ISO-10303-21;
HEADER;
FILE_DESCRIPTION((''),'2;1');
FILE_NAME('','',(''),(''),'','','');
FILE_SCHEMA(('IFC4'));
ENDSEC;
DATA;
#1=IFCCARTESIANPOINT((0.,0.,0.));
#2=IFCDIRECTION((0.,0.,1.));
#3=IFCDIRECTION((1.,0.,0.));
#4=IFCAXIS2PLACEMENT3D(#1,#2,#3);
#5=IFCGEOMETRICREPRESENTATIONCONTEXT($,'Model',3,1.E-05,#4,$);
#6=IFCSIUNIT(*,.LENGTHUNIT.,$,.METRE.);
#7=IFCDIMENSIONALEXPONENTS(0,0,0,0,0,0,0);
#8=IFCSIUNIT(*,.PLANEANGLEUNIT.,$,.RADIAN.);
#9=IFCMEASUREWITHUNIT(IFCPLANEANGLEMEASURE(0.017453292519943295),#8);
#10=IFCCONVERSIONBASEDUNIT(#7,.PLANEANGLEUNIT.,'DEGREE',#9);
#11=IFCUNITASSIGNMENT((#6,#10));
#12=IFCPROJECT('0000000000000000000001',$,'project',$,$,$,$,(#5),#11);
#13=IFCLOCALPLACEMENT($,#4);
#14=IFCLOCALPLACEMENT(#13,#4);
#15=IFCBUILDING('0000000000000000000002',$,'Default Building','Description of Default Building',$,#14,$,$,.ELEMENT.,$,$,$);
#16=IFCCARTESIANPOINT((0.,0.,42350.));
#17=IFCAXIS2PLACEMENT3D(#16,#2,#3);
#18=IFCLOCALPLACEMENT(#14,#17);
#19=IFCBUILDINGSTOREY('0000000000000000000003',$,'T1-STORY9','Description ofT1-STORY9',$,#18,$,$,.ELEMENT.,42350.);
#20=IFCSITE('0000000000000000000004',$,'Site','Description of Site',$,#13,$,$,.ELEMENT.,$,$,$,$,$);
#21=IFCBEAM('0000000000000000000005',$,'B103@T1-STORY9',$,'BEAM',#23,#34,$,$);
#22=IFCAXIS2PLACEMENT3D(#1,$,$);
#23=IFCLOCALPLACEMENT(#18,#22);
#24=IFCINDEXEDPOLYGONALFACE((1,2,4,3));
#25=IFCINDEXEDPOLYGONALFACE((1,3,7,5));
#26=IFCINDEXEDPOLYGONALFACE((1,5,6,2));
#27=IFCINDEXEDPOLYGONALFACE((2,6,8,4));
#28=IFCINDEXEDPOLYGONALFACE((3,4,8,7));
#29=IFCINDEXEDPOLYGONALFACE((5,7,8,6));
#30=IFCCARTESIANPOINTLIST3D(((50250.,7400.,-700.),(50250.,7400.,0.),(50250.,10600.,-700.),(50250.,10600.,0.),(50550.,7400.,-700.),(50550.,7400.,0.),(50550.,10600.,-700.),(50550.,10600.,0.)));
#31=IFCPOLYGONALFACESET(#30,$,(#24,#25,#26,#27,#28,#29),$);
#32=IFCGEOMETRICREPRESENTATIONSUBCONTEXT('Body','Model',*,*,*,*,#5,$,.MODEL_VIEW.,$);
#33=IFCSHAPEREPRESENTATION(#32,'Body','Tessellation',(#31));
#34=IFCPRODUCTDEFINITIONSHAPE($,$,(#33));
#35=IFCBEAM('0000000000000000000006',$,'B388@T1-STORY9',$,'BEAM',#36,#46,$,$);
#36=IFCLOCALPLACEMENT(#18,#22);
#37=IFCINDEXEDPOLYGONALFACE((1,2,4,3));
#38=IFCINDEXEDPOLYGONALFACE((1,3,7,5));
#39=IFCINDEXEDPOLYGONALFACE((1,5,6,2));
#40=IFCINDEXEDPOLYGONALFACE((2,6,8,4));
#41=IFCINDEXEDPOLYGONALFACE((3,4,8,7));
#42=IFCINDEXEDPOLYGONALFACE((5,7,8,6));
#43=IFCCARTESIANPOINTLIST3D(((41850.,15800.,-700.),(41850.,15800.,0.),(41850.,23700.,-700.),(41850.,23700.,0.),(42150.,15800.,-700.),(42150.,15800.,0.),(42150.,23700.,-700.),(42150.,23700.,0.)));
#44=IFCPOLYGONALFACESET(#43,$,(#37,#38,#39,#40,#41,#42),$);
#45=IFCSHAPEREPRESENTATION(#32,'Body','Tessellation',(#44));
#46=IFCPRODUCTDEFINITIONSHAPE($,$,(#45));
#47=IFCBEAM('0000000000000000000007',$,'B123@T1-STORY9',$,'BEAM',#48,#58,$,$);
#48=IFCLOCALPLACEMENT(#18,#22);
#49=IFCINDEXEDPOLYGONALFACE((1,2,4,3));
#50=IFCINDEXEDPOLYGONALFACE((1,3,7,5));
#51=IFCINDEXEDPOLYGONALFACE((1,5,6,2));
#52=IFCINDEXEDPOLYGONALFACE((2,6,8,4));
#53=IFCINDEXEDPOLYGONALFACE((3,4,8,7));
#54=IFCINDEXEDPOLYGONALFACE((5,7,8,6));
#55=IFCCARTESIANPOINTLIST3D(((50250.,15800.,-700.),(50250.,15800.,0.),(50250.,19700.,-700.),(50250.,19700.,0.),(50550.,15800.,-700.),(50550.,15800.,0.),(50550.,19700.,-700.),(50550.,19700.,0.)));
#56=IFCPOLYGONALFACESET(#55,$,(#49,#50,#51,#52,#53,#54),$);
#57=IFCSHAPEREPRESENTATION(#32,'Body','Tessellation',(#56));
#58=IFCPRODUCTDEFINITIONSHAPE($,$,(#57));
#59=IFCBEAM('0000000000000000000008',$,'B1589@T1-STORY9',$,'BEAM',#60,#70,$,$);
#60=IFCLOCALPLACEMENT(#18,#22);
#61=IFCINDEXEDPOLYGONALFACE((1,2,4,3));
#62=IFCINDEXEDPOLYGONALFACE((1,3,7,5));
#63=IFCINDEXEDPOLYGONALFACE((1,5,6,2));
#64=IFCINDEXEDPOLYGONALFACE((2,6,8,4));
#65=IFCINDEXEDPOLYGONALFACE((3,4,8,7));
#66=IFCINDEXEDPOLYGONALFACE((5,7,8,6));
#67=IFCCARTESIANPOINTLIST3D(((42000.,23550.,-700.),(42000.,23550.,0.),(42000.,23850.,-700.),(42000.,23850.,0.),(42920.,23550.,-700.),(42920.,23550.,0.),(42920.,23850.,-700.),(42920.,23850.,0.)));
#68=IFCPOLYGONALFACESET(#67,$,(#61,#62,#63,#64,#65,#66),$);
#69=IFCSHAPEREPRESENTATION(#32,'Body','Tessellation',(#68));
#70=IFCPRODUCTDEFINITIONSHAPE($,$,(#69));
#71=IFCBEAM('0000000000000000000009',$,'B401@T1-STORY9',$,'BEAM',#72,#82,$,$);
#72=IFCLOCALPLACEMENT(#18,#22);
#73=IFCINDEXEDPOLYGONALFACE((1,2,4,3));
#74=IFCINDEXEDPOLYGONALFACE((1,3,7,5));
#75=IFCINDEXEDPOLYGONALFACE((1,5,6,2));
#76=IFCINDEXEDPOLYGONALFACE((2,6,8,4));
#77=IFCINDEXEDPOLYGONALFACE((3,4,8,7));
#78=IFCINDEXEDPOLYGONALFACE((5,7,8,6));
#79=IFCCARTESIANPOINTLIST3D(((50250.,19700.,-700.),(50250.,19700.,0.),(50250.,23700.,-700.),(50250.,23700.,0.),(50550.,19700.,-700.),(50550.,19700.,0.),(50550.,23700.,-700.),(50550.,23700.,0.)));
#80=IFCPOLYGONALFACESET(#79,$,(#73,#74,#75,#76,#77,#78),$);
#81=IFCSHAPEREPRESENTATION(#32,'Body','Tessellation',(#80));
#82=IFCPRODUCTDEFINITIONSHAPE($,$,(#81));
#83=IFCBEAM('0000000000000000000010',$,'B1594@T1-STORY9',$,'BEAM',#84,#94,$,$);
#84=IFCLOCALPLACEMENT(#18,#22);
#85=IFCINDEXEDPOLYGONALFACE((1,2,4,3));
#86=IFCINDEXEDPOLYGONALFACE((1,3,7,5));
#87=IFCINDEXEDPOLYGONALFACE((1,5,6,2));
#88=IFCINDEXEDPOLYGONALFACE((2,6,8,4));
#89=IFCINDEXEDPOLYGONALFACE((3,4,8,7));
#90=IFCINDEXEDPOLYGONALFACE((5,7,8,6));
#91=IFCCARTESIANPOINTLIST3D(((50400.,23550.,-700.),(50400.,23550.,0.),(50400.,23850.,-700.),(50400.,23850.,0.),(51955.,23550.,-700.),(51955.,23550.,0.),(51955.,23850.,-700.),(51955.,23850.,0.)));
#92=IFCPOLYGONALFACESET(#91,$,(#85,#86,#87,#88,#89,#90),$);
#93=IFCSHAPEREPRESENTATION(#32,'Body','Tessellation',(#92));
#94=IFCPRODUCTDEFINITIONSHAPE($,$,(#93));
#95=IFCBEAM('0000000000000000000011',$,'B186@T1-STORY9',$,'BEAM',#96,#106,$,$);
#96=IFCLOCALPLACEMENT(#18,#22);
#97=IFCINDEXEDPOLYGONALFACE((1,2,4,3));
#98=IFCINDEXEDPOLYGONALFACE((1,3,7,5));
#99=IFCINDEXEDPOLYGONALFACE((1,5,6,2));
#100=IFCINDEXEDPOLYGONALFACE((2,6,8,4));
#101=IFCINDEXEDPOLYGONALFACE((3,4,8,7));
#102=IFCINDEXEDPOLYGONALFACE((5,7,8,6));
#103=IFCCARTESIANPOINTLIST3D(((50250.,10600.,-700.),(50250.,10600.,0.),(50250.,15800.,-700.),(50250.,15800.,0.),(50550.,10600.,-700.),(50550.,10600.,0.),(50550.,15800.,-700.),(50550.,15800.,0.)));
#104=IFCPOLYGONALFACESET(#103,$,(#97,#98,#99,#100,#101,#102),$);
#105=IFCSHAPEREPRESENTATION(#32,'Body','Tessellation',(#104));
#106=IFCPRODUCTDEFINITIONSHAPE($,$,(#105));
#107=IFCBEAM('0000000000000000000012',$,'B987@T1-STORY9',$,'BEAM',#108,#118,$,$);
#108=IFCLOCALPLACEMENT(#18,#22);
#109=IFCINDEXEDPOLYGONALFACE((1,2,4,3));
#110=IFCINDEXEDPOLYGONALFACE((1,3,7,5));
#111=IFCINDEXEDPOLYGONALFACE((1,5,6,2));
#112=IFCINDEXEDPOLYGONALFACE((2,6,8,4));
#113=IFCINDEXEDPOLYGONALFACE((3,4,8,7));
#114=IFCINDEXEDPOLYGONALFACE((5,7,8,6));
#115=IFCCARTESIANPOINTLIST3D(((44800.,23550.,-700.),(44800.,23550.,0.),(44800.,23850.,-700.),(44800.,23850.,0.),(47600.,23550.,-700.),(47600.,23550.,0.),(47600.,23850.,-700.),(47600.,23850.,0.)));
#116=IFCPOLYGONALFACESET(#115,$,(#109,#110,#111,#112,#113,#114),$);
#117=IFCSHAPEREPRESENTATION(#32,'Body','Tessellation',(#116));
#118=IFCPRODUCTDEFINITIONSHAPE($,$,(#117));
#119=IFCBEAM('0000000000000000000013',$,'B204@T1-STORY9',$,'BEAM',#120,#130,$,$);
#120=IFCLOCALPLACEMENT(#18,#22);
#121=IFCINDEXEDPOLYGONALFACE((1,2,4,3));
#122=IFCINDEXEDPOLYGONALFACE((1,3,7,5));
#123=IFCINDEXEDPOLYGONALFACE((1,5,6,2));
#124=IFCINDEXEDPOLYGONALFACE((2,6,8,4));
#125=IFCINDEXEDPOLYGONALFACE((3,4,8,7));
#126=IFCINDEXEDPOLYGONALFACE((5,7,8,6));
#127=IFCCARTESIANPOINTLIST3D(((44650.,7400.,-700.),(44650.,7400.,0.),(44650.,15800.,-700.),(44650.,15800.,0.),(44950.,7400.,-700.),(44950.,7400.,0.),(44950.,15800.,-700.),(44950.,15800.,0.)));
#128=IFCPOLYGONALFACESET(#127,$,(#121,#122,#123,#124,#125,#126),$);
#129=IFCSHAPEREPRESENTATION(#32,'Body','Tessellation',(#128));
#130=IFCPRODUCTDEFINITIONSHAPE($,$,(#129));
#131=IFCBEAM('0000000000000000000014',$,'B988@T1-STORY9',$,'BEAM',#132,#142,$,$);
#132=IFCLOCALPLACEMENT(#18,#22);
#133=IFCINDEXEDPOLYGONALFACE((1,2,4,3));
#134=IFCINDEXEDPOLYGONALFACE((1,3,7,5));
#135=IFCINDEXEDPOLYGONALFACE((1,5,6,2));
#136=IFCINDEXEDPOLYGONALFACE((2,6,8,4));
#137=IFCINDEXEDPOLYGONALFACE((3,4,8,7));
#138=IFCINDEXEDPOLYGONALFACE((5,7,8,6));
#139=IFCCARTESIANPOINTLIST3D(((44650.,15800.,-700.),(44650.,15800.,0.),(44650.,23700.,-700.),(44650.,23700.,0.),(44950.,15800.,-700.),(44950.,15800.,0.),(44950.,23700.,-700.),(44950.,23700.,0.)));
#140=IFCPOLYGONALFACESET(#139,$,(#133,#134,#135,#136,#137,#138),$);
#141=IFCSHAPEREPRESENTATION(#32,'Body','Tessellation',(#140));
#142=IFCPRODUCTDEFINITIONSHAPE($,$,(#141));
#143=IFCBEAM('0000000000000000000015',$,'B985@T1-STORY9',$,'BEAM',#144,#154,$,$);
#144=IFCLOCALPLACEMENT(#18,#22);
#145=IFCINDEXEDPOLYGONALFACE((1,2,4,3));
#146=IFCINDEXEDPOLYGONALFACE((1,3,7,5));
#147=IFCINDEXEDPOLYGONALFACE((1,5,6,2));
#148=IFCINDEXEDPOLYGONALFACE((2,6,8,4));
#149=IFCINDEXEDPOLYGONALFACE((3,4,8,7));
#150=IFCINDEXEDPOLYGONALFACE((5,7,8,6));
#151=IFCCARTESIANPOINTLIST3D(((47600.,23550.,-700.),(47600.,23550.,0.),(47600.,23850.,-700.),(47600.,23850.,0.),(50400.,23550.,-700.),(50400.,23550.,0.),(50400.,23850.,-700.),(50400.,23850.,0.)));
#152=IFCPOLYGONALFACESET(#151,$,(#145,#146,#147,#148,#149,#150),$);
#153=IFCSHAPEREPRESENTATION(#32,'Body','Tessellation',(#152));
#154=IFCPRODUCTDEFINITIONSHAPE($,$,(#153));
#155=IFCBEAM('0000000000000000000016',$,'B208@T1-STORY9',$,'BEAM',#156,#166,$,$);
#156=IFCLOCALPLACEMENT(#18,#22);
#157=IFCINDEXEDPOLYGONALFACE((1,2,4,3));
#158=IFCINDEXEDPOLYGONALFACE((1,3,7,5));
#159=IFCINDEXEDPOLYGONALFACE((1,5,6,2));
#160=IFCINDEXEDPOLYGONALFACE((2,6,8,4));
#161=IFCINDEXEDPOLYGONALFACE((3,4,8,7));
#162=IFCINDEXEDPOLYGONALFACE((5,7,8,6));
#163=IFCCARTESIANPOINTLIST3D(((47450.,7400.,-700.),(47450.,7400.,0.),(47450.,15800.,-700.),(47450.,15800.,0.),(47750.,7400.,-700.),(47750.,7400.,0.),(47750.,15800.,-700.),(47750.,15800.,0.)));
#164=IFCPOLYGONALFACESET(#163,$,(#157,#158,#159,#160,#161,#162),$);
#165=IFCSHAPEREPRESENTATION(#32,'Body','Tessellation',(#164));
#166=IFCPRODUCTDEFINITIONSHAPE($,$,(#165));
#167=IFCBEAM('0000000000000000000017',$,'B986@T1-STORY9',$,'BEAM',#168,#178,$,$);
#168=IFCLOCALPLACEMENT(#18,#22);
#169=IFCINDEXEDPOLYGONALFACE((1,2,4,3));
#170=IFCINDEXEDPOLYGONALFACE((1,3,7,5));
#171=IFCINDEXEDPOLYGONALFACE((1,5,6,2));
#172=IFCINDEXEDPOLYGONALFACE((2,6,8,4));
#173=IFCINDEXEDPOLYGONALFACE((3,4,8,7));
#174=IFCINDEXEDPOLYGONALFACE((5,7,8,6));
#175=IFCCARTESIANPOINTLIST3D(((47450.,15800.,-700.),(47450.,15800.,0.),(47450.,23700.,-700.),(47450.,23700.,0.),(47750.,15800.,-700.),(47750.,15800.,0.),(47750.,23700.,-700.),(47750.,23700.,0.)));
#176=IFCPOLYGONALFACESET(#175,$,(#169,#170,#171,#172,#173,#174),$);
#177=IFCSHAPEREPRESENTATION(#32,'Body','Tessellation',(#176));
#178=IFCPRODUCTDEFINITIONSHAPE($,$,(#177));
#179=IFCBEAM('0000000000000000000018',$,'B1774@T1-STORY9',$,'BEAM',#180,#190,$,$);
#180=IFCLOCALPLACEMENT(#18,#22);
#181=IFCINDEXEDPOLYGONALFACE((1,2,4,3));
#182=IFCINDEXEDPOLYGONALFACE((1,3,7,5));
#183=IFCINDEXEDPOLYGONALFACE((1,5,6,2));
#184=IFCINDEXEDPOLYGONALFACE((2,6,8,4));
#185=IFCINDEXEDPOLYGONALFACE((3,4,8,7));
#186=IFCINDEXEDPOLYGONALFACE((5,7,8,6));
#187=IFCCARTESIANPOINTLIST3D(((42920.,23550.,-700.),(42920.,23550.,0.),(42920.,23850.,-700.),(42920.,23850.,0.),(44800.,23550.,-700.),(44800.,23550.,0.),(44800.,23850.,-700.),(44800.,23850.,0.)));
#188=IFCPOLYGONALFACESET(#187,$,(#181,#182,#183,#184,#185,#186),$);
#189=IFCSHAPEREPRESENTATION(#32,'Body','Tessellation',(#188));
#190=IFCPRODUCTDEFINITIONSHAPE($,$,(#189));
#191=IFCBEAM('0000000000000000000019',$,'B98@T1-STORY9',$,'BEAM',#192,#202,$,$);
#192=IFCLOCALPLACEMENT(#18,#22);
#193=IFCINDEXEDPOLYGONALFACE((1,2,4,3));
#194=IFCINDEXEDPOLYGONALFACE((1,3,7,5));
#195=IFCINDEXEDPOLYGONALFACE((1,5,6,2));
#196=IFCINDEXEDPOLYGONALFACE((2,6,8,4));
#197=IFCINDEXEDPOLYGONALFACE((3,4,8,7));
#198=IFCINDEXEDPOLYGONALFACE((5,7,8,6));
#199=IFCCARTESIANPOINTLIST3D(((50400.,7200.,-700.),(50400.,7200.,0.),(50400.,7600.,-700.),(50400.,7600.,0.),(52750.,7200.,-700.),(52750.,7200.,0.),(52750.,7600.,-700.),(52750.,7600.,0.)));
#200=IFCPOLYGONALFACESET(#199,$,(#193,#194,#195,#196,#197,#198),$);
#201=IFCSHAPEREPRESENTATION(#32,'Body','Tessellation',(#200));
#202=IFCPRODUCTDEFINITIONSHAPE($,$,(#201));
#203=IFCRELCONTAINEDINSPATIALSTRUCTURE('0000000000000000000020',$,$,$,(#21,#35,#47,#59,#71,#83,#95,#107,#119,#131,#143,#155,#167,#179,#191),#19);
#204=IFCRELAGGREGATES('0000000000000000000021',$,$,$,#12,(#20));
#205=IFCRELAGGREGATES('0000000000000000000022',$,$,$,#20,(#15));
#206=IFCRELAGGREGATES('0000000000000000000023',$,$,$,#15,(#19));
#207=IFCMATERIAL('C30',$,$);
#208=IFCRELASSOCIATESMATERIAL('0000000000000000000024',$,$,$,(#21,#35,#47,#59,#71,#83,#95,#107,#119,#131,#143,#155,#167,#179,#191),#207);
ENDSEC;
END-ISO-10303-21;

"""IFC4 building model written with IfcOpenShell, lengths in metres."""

from ifc_helpers import new_model, entity, si_unit, converted_unit, frame, origin_with_axes, place, context, subcontext, project, spatial, rectangle, extrude, material, element, save


model = new_model("IFC4")

# Units and contexts
model_context = context("Model", 3, precision=1e-05, world=origin_with_axes())
body_context = subcontext(model_context, "Body", "Model", "MODEL_VIEW")
ifc_project = project(units=[si_unit("LENGTHUNIT", "METRE"), converted_unit("PLANEANGLEUNIT", "DEGREE", entity("IfcPlaneAngleMeasure", 0.017453292519943295), si_unit("PLANEANGLEUNIT", "RADIAN"), dimensions=[0, 0, 0, 0, 0, 0, 0])], contexts=[model_context])

# Site, building, storey
site_placement = place(None, origin_with_axes())
site = spatial("IfcSite", under=ifc_project, at=site_placement, Name="Site", Description="Description of Site", CompositionType="ELEMENT")
building_placement = place(site_placement, origin_with_axes())
building = spatial("IfcBuilding", under=site, at=building_placement, Name="Default Building", Description="Description of Default Building", CompositionType="ELEMENT")
storey_placement = place(building_placement, frame((0.0, 0.0, 42350.0), z_axis=(0.0, 0.0, 1.0), x_axis=(1.0, 0.0, 0.0)))
storey = spatial("IfcBuildingStorey", under=building, at=storey_placement, Name="T1-STORY9", Description="Description ofT1-STORY9", CompositionType="ELEMENT", Elevation=42350.0)

# Beams
ifc_material_1 = material(Name="C30")
beam_1_placement = place(storey_placement, frame((50400.0, 7400.0, -350.0), z_axis=(0.0, 1.0, 0.0), x_axis=(-1.0, 0.0, 0.0)))
element("IfcBeam", 1, at=beam_1_placement, inside=storey, material=ifc_material_1, Name="B103@T1-STORY9", ObjectType="BEAM", context=body_context, shape_type="SweptSolid", body=[
    extrude(rectangle(XDim=300.0, YDim=700.0), origin_with_axes(), (0.0, 0.0, 1.0), 3200.0),
])
beam_2_placement = place(storey_placement, frame((42000.0, 15800.0, -350.0), z_axis=(0.0, 1.0, 0.0), x_axis=(-1.0, 0.0, 0.0)))
element("IfcBeam", 2, at=beam_2_placement, inside=storey, material=ifc_material_1, Name="B388@T1-STORY9", ObjectType="BEAM", context=body_context, shape_type="SweptSolid", body=[
    extrude(rectangle(XDim=300.0, YDim=700.0), origin_with_axes(), (0.0, 0.0, 1.0), 7900.0),
])
beam_3_placement = place(storey_placement, frame((50400.0, 15800.0, -350.0), z_axis=(0.0, 1.0, 0.0), x_axis=(-1.0, 0.0, 0.0)))
element("IfcBeam", 3, at=beam_3_placement, inside=storey, material=ifc_material_1, Name="B123@T1-STORY9", ObjectType="BEAM", context=body_context, shape_type="SweptSolid", body=[
    extrude(rectangle(XDim=300.0, YDim=700.0), origin_with_axes(), (0.0, 0.0, 1.0), 3900.0),
])
beam_4_placement = place(storey_placement, frame((42000.0, 23700.0, -350.0), z_axis=(1.0, 0.0, 0.0), x_axis=(0.0, 1.0, 0.0)))
element("IfcBeam", 4, at=beam_4_placement, inside=storey, material=ifc_material_1, Name="B1589@T1-STORY9", ObjectType="BEAM", context=body_context, shape_type="SweptSolid", body=[
    extrude(rectangle(XDim=300.0, YDim=700.0), origin_with_axes(), (0.0, 0.0, 1.0), 920.0),
])
beam_5_placement = place(storey_placement, frame((50400.0, 19700.0, -350.0), z_axis=(0.0, 1.0, 0.0), x_axis=(-1.0, 0.0, 0.0)))
element("IfcBeam", 5, at=beam_5_placement, inside=storey, material=ifc_material_1, Name="B401@T1-STORY9", ObjectType="BEAM", context=body_context, shape_type="SweptSolid", body=[
    extrude(rectangle(XDim=300.0, YDim=700.0), origin_with_axes(), (0.0, 0.0, 1.0), 4000.0),
])
beam_6_placement = place(storey_placement, frame((50400.0, 23700.0, -350.0), z_axis=(1.0, 0.0, 0.0), x_axis=(0.0, 1.0, 0.0)))
element("IfcBeam", 6, at=beam_6_placement, inside=storey, material=ifc_material_1, Name="B1594@T1-STORY9", ObjectType="BEAM", context=body_context, shape_type="SweptSolid", body=[
    extrude(rectangle(XDim=300.0, YDim=700.0), origin_with_axes(), (0.0, 0.0, 1.0), 1555.0),
])
beam_7_placement = place(storey_placement, frame((50400.0, 10600.0, -350.0), z_axis=(0.0, 1.0, 0.0), x_axis=(-1.0, 0.0, 0.0)))
element("IfcBeam", 7, at=beam_7_placement, inside=storey, material=ifc_material_1, Name="B186@T1-STORY9", ObjectType="BEAM", context=body_context, shape_type="SweptSolid", body=[
    extrude(rectangle(XDim=300.0, YDim=700.0), origin_with_axes(), (0.0, 0.0, 1.0), 5200.0),
])
beam_8_placement = place(storey_placement, frame((44800.0, 23700.0, -350.0), z_axis=(1.0, 0.0, 0.0), x_axis=(0.0, 1.0, 0.0)))
element("IfcBeam", 8, at=beam_8_placement, inside=storey, material=ifc_material_1, Name="B987@T1-STORY9", ObjectType="BEAM", context=body_context, shape_type="SweptSolid", body=[
    extrude(rectangle(XDim=300.0, YDim=700.0), origin_with_axes(), (0.0, 0.0, 1.0), 2800.0),
])
beam_9_placement = place(storey_placement, frame((44800.0, 7400.0, -350.0), z_axis=(0.0, 1.0, 0.0), x_axis=(-1.0, 0.0, 0.0)))
element("IfcBeam", 9, at=beam_9_placement, inside=storey, material=ifc_material_1, Name="B204@T1-STORY9", ObjectType="BEAM", context=body_context, shape_type="SweptSolid", body=[
    extrude(rectangle(XDim=300.0, YDim=700.0), origin_with_axes(), (0.0, 0.0, 1.0), 8400.0),
])
beam_10_placement = place(storey_placement, frame((44800.0, 15800.0, -350.0), z_axis=(0.0, 1.0, 0.0), x_axis=(-1.0, 0.0, 0.0)))
element("IfcBeam", 10, at=beam_10_placement, inside=storey, material=ifc_material_1, Name="B988@T1-STORY9", ObjectType="BEAM", context=body_context, shape_type="SweptSolid", body=[
    extrude(rectangle(XDim=300.0, YDim=700.0), origin_with_axes(), (0.0, 0.0, 1.0), 7900.0),
])
beam_11_placement = place(storey_placement, frame((47600.0, 23700.0, -350.0), z_axis=(1.0, 0.0, 0.0), x_axis=(0.0, 1.0, 0.0)))
element("IfcBeam", 11, at=beam_11_placement, inside=storey, material=ifc_material_1, Name="B985@T1-STORY9", ObjectType="BEAM", context=body_context, shape_type="SweptSolid", body=[
    extrude(rectangle(XDim=300.0, YDim=700.0), origin_with_axes(), (0.0, 0.0, 1.0), 2800.0),
])
beam_12_placement = place(storey_placement, frame((47600.0, 7400.0, -350.0), z_axis=(0.0, 1.0, 0.0), x_axis=(-1.0, 0.0, 0.0)))
element("IfcBeam", 12, at=beam_12_placement, inside=storey, material=ifc_material_1, Name="B208@T1-STORY9", ObjectType="BEAM", context=body_context, shape_type="SweptSolid", body=[
    extrude(rectangle(XDim=300.0, YDim=700.0), origin_with_axes(), (0.0, 0.0, 1.0), 8400.0),
])
beam_13_placement = place(storey_placement, frame((47600.0, 15800.0, -350.0), z_axis=(0.0, 1.0, 0.0), x_axis=(-1.0, 0.0, 0.0)))
element("IfcBeam", 13, at=beam_13_placement, inside=storey, material=ifc_material_1, Name="B986@T1-STORY9", ObjectType="BEAM", context=body_context, shape_type="SweptSolid", body=[
    extrude(rectangle(XDim=300.0, YDim=700.0), origin_with_axes(), (0.0, 0.0, 1.0), 7900.0),
])
beam_14_placement = place(storey_placement, frame((42920.0, 23700.0, -350.0), z_axis=(1.0, 0.0, 0.0), x_axis=(0.0, 1.0, 0.0)))
element("IfcBeam", 14, at=beam_14_placement, inside=storey, material=ifc_material_1, Name="B1774@T1-STORY9", ObjectType="BEAM", context=body_context, shape_type="SweptSolid", body=[
    extrude(rectangle(XDim=300.0, YDim=700.0), origin_with_axes(), (0.0, 0.0, 1.0), 1880.0),
])
beam_15_placement = place(storey_placement, frame((50400.0, 7400.0, -350.0), z_axis=(1.0, 0.0, 0.0), x_axis=(0.0, 1.0, 0.0)))
element("IfcBeam", 15, at=beam_15_placement, inside=storey, material=ifc_material_1, Name="B98@T1-STORY9", ObjectType="BEAM", context=body_context, shape_type="SweptSolid", body=[
    extrude(rectangle(XDim=400.0, YDim=700.0), origin_with_axes(), (0.0, 0.0, 1.0), 2350.0),
])

save(model, "model.ifc")
